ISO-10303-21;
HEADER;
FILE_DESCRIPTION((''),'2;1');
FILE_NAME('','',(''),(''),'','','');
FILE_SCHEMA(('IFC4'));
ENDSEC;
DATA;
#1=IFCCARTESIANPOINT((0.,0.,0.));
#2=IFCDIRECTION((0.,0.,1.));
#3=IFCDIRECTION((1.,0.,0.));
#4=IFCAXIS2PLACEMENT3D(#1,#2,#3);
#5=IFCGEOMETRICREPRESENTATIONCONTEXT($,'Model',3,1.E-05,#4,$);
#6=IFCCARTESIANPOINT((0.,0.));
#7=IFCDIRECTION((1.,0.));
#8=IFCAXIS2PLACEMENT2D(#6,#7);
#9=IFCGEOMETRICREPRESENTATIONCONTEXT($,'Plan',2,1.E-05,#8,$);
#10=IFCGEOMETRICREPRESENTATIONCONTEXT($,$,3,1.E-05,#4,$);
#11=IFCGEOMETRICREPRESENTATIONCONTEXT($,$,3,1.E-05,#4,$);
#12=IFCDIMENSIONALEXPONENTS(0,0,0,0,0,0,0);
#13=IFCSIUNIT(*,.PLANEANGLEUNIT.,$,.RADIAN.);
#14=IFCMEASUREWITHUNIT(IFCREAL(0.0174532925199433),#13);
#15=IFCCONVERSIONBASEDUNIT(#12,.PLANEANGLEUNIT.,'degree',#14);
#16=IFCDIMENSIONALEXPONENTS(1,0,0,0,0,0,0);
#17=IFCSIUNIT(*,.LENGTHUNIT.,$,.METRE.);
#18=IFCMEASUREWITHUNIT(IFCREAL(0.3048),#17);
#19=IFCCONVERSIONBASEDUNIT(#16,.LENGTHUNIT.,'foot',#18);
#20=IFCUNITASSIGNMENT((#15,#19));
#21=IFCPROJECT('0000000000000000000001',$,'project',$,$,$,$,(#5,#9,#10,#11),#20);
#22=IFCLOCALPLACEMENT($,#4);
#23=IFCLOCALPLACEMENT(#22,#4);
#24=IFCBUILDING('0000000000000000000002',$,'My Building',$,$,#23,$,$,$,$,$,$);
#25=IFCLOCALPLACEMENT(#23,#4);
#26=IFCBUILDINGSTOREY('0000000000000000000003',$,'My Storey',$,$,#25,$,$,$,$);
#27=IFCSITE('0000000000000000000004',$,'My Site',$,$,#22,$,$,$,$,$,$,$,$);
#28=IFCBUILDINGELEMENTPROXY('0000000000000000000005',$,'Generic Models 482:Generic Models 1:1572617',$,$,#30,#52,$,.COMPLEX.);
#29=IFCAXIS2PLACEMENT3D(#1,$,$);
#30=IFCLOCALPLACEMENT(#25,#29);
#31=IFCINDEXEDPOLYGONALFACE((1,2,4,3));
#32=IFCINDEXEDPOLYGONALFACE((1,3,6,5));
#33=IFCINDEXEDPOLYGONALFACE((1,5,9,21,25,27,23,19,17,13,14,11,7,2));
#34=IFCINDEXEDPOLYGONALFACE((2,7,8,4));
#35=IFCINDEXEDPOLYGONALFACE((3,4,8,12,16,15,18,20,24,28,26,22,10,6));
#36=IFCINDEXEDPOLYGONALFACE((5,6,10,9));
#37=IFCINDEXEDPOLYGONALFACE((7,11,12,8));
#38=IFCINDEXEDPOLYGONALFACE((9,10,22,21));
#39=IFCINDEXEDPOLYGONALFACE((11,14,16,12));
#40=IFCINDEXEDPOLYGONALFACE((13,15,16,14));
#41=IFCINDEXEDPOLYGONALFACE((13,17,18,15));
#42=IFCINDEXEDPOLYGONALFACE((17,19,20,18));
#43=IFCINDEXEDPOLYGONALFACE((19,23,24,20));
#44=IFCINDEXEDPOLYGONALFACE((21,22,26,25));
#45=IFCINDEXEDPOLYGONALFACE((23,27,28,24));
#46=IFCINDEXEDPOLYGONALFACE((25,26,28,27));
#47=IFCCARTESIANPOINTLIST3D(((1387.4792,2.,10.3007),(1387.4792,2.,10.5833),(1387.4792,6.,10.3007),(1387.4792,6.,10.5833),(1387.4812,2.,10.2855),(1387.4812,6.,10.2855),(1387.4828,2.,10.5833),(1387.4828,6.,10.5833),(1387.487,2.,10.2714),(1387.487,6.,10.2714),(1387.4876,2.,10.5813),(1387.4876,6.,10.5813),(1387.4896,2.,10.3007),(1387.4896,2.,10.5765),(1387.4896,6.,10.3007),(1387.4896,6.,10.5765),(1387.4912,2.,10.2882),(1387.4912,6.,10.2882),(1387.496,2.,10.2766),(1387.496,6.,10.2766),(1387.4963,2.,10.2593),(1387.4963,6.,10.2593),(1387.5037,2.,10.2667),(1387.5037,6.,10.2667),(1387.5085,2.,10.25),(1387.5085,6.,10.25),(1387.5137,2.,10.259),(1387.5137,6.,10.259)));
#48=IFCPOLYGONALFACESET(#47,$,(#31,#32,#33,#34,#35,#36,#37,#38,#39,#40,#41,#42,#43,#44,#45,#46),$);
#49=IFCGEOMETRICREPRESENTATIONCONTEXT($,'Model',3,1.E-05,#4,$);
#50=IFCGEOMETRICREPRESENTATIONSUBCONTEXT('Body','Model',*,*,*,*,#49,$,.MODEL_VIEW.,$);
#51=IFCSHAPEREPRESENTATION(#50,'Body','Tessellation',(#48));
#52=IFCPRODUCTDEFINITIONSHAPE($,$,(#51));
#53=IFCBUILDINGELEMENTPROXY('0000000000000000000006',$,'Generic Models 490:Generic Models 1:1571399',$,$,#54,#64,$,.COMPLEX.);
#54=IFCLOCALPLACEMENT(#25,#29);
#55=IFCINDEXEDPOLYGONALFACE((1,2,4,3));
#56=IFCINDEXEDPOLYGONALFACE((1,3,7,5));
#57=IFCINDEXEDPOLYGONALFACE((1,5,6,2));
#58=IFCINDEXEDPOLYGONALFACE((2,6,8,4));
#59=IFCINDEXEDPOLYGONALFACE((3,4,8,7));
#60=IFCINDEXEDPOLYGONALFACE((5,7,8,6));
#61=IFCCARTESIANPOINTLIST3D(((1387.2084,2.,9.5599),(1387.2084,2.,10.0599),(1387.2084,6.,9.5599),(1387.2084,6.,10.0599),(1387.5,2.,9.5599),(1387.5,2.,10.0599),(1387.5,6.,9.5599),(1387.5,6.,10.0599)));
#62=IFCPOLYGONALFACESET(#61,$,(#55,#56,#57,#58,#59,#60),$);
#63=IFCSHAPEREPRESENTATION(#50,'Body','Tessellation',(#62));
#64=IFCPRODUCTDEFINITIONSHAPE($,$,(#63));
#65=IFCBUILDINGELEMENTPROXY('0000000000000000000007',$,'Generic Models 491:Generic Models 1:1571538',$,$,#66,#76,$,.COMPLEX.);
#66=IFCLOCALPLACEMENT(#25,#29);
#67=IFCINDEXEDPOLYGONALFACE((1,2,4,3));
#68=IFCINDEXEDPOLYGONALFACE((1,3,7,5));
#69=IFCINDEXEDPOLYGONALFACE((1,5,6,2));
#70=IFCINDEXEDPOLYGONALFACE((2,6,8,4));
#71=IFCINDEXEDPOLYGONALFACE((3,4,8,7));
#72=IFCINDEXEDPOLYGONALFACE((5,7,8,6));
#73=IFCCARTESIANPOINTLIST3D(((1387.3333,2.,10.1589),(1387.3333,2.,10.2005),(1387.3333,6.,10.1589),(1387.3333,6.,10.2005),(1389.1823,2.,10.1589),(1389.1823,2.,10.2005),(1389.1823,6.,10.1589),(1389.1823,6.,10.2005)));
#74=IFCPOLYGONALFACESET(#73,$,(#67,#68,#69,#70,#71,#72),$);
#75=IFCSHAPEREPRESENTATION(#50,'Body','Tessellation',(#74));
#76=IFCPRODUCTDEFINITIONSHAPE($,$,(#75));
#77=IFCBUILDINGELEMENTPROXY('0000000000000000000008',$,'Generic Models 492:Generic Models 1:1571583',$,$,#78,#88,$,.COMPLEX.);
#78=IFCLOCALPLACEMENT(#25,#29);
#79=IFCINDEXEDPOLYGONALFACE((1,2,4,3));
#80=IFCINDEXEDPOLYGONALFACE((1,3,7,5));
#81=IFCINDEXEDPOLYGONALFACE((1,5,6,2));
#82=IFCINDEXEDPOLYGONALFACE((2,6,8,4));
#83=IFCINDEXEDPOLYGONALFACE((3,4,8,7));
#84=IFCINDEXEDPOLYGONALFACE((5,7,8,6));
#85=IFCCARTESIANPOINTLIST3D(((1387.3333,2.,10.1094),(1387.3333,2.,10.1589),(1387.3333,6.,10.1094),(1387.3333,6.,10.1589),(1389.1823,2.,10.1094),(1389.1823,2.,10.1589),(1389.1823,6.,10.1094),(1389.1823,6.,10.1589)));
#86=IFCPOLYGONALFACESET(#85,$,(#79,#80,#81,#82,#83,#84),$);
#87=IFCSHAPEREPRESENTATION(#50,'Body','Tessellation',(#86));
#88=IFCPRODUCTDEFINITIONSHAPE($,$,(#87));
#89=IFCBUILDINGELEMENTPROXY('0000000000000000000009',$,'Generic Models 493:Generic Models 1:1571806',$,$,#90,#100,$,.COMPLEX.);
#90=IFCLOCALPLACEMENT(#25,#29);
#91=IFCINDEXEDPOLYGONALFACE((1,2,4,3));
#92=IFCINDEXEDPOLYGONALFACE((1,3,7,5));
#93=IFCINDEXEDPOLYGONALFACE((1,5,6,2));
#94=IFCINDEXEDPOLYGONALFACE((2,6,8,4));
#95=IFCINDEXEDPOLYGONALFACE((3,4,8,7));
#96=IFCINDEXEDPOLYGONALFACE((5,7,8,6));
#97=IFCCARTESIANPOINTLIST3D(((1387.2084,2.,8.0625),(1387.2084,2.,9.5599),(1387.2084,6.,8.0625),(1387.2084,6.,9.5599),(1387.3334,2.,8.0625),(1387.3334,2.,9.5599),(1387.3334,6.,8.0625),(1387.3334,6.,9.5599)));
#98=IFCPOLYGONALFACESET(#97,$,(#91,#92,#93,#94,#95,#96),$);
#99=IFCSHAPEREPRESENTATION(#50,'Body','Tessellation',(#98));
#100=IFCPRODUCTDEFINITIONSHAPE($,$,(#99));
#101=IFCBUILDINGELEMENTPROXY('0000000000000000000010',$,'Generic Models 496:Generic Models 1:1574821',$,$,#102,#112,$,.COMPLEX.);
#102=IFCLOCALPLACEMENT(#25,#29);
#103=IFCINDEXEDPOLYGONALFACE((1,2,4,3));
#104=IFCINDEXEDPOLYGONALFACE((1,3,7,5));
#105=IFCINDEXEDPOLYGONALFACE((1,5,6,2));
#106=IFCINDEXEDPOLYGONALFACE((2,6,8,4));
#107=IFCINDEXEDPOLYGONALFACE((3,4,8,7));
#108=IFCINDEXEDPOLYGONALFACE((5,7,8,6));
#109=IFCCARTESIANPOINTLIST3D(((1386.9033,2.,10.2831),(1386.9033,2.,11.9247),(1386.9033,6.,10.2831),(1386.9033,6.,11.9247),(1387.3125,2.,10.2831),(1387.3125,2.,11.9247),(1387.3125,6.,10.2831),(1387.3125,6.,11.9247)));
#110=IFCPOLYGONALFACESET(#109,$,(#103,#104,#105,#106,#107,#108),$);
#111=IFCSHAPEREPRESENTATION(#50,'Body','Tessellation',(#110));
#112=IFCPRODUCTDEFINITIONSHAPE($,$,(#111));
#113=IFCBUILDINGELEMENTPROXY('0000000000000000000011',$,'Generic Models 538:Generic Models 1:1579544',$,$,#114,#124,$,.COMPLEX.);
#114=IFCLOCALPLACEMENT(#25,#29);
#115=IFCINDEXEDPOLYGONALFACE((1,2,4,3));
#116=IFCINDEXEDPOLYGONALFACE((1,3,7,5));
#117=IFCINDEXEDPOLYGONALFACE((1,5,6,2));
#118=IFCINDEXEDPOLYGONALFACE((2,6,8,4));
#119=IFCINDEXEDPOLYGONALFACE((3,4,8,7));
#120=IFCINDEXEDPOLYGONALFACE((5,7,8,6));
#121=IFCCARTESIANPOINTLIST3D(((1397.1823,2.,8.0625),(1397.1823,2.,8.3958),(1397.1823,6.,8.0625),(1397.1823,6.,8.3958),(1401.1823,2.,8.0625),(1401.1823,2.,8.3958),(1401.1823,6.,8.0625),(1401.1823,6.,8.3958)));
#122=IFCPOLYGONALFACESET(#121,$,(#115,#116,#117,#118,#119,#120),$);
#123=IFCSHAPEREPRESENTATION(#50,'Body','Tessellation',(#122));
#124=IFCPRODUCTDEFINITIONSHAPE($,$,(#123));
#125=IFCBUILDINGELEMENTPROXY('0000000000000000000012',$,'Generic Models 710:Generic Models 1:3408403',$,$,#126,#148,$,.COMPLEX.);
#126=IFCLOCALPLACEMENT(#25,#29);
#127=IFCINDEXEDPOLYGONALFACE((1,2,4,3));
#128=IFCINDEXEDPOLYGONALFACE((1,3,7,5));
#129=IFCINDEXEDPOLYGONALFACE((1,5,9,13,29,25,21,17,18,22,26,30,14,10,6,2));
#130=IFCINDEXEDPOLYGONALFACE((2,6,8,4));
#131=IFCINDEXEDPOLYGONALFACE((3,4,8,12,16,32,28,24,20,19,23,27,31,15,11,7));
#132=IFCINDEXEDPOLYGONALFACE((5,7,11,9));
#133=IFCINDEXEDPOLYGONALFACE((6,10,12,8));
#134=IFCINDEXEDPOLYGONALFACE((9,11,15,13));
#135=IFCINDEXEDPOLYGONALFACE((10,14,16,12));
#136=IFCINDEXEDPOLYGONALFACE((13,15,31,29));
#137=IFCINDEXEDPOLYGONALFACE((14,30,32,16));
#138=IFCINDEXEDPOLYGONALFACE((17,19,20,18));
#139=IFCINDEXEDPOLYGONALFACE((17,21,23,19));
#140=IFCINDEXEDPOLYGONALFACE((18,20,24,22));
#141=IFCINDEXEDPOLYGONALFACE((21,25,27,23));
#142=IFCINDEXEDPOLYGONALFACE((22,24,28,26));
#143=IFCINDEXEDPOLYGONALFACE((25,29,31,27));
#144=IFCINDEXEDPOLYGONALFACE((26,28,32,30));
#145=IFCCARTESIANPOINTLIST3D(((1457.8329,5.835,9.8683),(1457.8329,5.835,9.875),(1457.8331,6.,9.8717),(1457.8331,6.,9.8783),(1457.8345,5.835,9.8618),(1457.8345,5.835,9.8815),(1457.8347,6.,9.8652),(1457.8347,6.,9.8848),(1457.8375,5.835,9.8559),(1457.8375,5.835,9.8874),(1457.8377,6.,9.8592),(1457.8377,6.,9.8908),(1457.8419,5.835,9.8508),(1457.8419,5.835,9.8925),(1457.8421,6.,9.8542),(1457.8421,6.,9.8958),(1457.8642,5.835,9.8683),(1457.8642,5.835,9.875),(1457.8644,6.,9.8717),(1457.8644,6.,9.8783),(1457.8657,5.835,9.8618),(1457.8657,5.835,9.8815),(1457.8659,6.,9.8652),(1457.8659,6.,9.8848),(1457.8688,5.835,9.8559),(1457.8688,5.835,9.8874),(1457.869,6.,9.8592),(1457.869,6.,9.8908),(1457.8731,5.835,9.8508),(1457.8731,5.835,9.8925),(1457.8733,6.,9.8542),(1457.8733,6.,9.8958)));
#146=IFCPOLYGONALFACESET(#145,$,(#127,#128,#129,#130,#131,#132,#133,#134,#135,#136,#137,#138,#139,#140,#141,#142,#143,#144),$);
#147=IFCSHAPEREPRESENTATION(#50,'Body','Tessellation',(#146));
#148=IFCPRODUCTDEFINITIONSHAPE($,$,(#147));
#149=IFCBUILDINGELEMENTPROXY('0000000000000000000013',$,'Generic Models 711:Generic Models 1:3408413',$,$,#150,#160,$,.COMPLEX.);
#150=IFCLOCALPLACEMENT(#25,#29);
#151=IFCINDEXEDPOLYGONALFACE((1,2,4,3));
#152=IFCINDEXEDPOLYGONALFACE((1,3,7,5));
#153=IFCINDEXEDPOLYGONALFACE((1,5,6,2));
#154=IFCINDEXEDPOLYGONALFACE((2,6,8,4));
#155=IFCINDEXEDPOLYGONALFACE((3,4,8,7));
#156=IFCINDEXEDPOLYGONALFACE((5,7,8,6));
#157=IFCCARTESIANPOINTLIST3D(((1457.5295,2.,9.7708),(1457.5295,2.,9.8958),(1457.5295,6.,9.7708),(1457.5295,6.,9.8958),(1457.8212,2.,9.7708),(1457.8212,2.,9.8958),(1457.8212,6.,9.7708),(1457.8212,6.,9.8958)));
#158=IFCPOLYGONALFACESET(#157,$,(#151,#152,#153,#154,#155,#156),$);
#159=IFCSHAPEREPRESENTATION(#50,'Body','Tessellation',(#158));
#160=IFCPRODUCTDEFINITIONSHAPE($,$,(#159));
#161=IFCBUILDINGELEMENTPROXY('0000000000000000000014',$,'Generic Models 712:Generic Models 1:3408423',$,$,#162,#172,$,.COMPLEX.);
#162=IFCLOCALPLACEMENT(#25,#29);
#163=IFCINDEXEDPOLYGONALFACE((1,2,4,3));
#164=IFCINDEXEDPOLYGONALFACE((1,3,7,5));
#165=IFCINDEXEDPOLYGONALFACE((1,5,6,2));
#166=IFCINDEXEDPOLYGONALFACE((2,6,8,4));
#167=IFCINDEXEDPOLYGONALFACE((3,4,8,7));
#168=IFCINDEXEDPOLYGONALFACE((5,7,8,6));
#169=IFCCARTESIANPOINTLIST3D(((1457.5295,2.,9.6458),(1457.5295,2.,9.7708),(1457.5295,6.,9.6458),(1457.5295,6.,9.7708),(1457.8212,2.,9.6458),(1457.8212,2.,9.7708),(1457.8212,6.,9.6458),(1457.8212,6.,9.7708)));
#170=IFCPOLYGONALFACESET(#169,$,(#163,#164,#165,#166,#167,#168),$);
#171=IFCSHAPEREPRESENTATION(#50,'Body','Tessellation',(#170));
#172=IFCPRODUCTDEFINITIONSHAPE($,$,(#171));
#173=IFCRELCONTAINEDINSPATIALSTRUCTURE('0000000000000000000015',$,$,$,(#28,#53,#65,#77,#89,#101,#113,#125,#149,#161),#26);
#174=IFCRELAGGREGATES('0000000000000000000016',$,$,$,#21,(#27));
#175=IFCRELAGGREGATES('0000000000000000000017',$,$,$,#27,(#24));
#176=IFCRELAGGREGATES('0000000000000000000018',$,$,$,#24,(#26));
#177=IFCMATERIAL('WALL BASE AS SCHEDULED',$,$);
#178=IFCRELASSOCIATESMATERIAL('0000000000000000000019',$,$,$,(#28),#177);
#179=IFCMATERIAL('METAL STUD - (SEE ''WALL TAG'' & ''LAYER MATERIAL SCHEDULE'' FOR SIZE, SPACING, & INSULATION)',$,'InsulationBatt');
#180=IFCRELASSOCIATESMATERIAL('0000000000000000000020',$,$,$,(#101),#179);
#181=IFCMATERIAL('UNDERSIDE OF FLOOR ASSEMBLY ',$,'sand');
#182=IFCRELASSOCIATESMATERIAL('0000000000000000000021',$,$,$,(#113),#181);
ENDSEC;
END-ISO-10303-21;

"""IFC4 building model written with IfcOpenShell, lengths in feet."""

from ifc_helpers import new_model, entity, si_unit, converted_unit, frame, origin_with_axes, origin_2d_with_axis, place, context, subcontext, project, spatial, polyline, outline, extrude, material, element, save


model = new_model("IFC4")

# Units and contexts
model_context_1 = context("Model", 3, precision=1e-05, world=origin_with_axes())
plan_context = context("Plan", 2, precision=1e-05, world=origin_2d_with_axis())
model_context_2 = context("Model", 3, precision=1e-05, world=origin_with_axes())
context_of_model_1 = context(None, 3, precision=1e-05, world=origin_with_axes())
context_of_model_2 = context(None, 3, precision=1e-05, world=origin_with_axes())
body_context_1 = subcontext(model_context_2, "Body", "Model", "MODEL_VIEW")
ifc_project = project(units=[converted_unit("PLANEANGLEUNIT", "degree", entity("IfcReal", 0.0174532925199433), si_unit("PLANEANGLEUNIT", "RADIAN"), dimensions=[0, 0, 0, 0, 0, 0, 0]), converted_unit("LENGTHUNIT", "foot", entity("IfcReal", 0.3048), si_unit("LENGTHUNIT", "METRE"), dimensions=[1, 0, 0, 0, 0, 0, 0])], contexts=[model_context_1, plan_context, context_of_model_1, context_of_model_2])

# Site, building, storey
site_placement = place(None, origin_with_axes())
site = spatial("IfcSite", under=ifc_project, at=site_placement, Name="My Site")
building_placement = place(site_placement, origin_with_axes())
building = spatial("IfcBuilding", under=site, at=building_placement, Name="My Building")
storey_placement = place(building_placement, origin_with_axes())
storey = spatial("IfcBuildingStorey", under=building, at=storey_placement, Name="My Storey")

# Building element proxies
ifc_material_1 = material(Name="WALL BASE AS SCHEDULED")
proxy_1_placement = place(storey_placement, frame((1387.4792, 6.0, 10.25), z_axis=(0.0, -1.0, 0.0), x_axis=(0.0, 0.0, 1.0)))
element("IfcBuildingElementProxy", 1, at=proxy_1_placement, inside=storey, material=ifc_material_1, Name="Generic Models 482:Generic Models 1:1572617", PredefinedType="COMPLEX", context=body_context_1, shape_type="SweptSolid", body=[
    extrude(outline(polyline([(0.2206, 0.0), (0.2204, 0.0036), (0.2182, 0.0083), (0.2132, 0.01), (-0.0621, -0.0058), (-0.0747, -0.0049), (-0.0865, -0.0007), (-0.0969, 0.0063), (-0.1051, 0.0158), (-0.1138, 0.0101), (-0.1038, -0.0014), (-0.0912, -0.01), (-0.0768, -0.0151), (-0.0615, -0.0162), (0.2206, 0.0)])), frame((0.113, -0.0126, 0.0), z_axis=(0.0, 0.0, -1.0), x_axis=(0.998358, 0.057286, 0.0)), (0.0, 0.0, -1.0), 4.0),
])
proxy_2_placement = place(storey_placement, frame((1387.2084, 6.0, 9.5599), z_axis=(0.0, -1.0, 0.0), x_axis=(0.0, 0.0, 1.0)))
element("IfcBuildingElementProxy", 2, at=proxy_2_placement, inside=storey, Name="Generic Models 490:Generic Models 1:1571399", PredefinedType="COMPLEX", context=body_context_1, shape_type="SweptSolid", body=[
    extrude(outline(polyline([(-0.25, -0.1458), (0.25, -0.1458), (0.25, 0.1458), (-0.25, 0.1458), (-0.25, -0.1458)])), frame((0.25, -0.1458, 0.0), z_axis=(0.0, 0.0, -1.0), x_axis=(-1.0, 0.0, 0.0)), (0.0, 0.0, -1.0), 4.0),
])
proxy_3_placement = place(storey_placement, frame((1387.3333, 6.0, 10.1589), z_axis=(0.0, -1.0, 0.0), x_axis=(0.0, 0.0, 1.0)))
element("IfcBuildingElementProxy", 3, at=proxy_3_placement, inside=storey, Name="Generic Models 491:Generic Models 1:1571538", PredefinedType="COMPLEX", context=body_context_1, shape_type="SweptSolid", body=[
    extrude(outline(polyline([(-0.0208, -0.9245), (0.0208, -0.9245), (0.0208, 0.9245), (-0.0208, 0.9245), (-0.0208, -0.9245)])), frame((0.0208, -0.9245, 0.0), z_axis=(0.0, 0.0, -1.0), x_axis=(-1.0, 0.0, 0.0)), (0.0, 0.0, -1.0), 4.0),
])
proxy_4_placement = place(storey_placement, frame((1387.3333, 6.0, 10.1094), z_axis=(0.0, -1.0, 0.0), x_axis=(0.0, 0.0, 1.0)))
element("IfcBuildingElementProxy", 4, at=proxy_4_placement, inside=storey, Name="Generic Models 492:Generic Models 1:1571583", PredefinedType="COMPLEX", context=body_context_1, shape_type="SweptSolid", body=[
    extrude(outline(polyline([(-0.0247, -0.9245), (0.0247, -0.9245), (0.0247, 0.9245), (-0.0247, 0.9245), (-0.0247, -0.9245)])), frame((0.0247, -0.9245, 0.0), z_axis=(0.0, 0.0, -1.0), x_axis=(-1.0, 0.0, 0.0)), (0.0, 0.0, -1.0), 4.0),
])
proxy_5_placement = place(storey_placement, frame((1387.2084, 6.0, 8.0625), z_axis=(0.0, -1.0, 0.0), x_axis=(0.0, 0.0, 1.0)))
element("IfcBuildingElementProxy", 5, at=proxy_5_placement, inside=storey, Name="Generic Models 493:Generic Models 1:1571806", PredefinedType="COMPLEX", context=body_context_1, shape_type="SweptSolid", body=[
    extrude(outline(polyline([(-0.7487, -0.0625), (0.7487, -0.0625), (0.7487, 0.0625), (-0.7487, 0.0625), (-0.7487, -0.0625)])), frame((0.7487, -0.0625, 0.0), z_axis=(0.0, 0.0, -1.0), x_axis=(-1.0, 0.0, 0.0)), (0.0, 0.0, -1.0), 4.0),
])
ifc_material_2 = material(Name="METAL STUD - (SEE 'WALL TAG' & 'LAYER MATERIAL SCHEDULE' FOR SIZE, SPACING, & INSULATION)", Category="InsulationBatt")
proxy_6_placement = place(storey_placement, frame((1386.9033, 6.0, 10.2831), z_axis=(0.0, -1.0, 0.0), x_axis=(0.0, 0.0, 1.0)))
element("IfcBuildingElementProxy", 6, at=proxy_6_placement, inside=storey, material=ifc_material_2, Name="Generic Models 496:Generic Models 1:1574821", PredefinedType="COMPLEX", context=body_context_1, shape_type="SweptSolid", body=[
    extrude(outline(polyline([(-0.8208, -0.2046), (0.8208, -0.2046), (0.8208, 0.2046), (-0.8208, 0.2046), (-0.8208, -0.2046)])), frame((0.8208, -0.2046, 0.0), z_axis=(0.0, 0.0, -1.0), x_axis=(1.0, 0.0, 0.0)), (0.0, 0.0, -1.0), 4.0),
])
ifc_material_3 = material(Name="UNDERSIDE OF FLOOR ASSEMBLY ", Category="sand")
proxy_7_placement = place(storey_placement, frame((1397.1823, 6.0, 8.0625), z_axis=(0.0, -1.0, 0.0), x_axis=(0.0, 0.0, 1.0)))
element("IfcBuildingElementProxy", 7, at=proxy_7_placement, inside=storey, material=ifc_material_3, Name="Generic Models 538:Generic Models 1:1579544", PredefinedType="COMPLEX", context=body_context_1, shape_type="SweptSolid", body=[
    extrude(outline(polyline([(-0.1667, -2.0), (0.1667, -2.0), (0.1667, 2.0), (-0.1667, 2.0), (-0.1667, -2.0)])), frame((0.1667, -2.0, 0.0), z_axis=(0.0, 0.0, -1.0), x_axis=(1.0, 0.0, 0.0)), (0.0, 0.0, -1.0), 4.0),
])
proxy_8_placement = place(storey_placement, frame((1457.8331, 6.0, 9.8542), z_axis=(0.0, -1.0, 0.0), x_axis=(0.0, 0.0, 1.0)))
element("IfcBuildingElementProxy", 8, at=proxy_8_placement, inside=storey, Name="Generic Models 710:Generic Models 1:3408403", PredefinedType="COMPLEX", context=body_context_1, shape_type="SweptSolid", body=[
    extrude(outline(polyline([(0.0166, 0.0), (0.0115, 0.0043), (0.0076, 0.0097), (0.005, 0.0159), (0.0039, 0.0224), (0.0045, 0.0291), (-0.0207, 0.0106), (-0.0213, 0.004), (-0.0202, -0.0026), (-0.0176, -0.0088), (-0.0137, -0.0142), (-0.0086, -0.0185), (-0.0026, -0.0215), (0.0039, -0.023), (0.0291, -0.0045), (0.0226, -0.003), (0.0166, 0.0)])), frame((0.0208, -0.0194, 0.0), z_axis=(0.0, 0.0, -1.0), x_axis=(0.591192, -0.806531, 0.0)), (-0.012926, 0.015608, -0.999795), 0.165),
])
proxy_9_placement = place(storey_placement, frame((1457.5295, 6.0, 9.7708), z_axis=(0.0, -1.0, 0.0), x_axis=(0.0, 0.0, 1.0)))
element("IfcBuildingElementProxy", 9, at=proxy_9_placement, inside=storey, Name="Generic Models 711:Generic Models 1:3408413", PredefinedType="COMPLEX", context=body_context_1, shape_type="SweptSolid", body=[
    extrude(outline(polyline([(-0.0625, -0.1458), (0.0625, -0.1458), (0.0625, 0.1458), (-0.0625, 0.1458), (-0.0625, -0.1458)])), frame((0.0625, -0.1458, 0.0), z_axis=(0.0, 0.0, -1.0), x_axis=(-1.0, 0.0, 0.0)), (0.0, 0.0, -1.0), 4.0),
])
proxy_10_placement = place(storey_placement, frame((1457.5295, 6.0, 9.6458), z_axis=(0.0, -1.0, 0.0), x_axis=(0.0, 0.0, 1.0)))
element("IfcBuildingElementProxy", 10, at=proxy_10_placement, inside=storey, Name="Generic Models 712:Generic Models 1:3408423", PredefinedType="COMPLEX", context=body_context_1, shape_type="SweptSolid", body=[
    extrude(outline(polyline([(-0.0625, -0.1458), (0.0625, -0.1458), (0.0625, 0.1458), (-0.0625, 0.1458), (-0.0625, -0.1458)])), frame((0.0625, -0.1458, 0.0), z_axis=(0.0, 0.0, -1.0), x_axis=(1.0, 0.0, 0.0)), (0.0, 0.0, -1.0), 4.0),
])

save(model, "model.ifc")
